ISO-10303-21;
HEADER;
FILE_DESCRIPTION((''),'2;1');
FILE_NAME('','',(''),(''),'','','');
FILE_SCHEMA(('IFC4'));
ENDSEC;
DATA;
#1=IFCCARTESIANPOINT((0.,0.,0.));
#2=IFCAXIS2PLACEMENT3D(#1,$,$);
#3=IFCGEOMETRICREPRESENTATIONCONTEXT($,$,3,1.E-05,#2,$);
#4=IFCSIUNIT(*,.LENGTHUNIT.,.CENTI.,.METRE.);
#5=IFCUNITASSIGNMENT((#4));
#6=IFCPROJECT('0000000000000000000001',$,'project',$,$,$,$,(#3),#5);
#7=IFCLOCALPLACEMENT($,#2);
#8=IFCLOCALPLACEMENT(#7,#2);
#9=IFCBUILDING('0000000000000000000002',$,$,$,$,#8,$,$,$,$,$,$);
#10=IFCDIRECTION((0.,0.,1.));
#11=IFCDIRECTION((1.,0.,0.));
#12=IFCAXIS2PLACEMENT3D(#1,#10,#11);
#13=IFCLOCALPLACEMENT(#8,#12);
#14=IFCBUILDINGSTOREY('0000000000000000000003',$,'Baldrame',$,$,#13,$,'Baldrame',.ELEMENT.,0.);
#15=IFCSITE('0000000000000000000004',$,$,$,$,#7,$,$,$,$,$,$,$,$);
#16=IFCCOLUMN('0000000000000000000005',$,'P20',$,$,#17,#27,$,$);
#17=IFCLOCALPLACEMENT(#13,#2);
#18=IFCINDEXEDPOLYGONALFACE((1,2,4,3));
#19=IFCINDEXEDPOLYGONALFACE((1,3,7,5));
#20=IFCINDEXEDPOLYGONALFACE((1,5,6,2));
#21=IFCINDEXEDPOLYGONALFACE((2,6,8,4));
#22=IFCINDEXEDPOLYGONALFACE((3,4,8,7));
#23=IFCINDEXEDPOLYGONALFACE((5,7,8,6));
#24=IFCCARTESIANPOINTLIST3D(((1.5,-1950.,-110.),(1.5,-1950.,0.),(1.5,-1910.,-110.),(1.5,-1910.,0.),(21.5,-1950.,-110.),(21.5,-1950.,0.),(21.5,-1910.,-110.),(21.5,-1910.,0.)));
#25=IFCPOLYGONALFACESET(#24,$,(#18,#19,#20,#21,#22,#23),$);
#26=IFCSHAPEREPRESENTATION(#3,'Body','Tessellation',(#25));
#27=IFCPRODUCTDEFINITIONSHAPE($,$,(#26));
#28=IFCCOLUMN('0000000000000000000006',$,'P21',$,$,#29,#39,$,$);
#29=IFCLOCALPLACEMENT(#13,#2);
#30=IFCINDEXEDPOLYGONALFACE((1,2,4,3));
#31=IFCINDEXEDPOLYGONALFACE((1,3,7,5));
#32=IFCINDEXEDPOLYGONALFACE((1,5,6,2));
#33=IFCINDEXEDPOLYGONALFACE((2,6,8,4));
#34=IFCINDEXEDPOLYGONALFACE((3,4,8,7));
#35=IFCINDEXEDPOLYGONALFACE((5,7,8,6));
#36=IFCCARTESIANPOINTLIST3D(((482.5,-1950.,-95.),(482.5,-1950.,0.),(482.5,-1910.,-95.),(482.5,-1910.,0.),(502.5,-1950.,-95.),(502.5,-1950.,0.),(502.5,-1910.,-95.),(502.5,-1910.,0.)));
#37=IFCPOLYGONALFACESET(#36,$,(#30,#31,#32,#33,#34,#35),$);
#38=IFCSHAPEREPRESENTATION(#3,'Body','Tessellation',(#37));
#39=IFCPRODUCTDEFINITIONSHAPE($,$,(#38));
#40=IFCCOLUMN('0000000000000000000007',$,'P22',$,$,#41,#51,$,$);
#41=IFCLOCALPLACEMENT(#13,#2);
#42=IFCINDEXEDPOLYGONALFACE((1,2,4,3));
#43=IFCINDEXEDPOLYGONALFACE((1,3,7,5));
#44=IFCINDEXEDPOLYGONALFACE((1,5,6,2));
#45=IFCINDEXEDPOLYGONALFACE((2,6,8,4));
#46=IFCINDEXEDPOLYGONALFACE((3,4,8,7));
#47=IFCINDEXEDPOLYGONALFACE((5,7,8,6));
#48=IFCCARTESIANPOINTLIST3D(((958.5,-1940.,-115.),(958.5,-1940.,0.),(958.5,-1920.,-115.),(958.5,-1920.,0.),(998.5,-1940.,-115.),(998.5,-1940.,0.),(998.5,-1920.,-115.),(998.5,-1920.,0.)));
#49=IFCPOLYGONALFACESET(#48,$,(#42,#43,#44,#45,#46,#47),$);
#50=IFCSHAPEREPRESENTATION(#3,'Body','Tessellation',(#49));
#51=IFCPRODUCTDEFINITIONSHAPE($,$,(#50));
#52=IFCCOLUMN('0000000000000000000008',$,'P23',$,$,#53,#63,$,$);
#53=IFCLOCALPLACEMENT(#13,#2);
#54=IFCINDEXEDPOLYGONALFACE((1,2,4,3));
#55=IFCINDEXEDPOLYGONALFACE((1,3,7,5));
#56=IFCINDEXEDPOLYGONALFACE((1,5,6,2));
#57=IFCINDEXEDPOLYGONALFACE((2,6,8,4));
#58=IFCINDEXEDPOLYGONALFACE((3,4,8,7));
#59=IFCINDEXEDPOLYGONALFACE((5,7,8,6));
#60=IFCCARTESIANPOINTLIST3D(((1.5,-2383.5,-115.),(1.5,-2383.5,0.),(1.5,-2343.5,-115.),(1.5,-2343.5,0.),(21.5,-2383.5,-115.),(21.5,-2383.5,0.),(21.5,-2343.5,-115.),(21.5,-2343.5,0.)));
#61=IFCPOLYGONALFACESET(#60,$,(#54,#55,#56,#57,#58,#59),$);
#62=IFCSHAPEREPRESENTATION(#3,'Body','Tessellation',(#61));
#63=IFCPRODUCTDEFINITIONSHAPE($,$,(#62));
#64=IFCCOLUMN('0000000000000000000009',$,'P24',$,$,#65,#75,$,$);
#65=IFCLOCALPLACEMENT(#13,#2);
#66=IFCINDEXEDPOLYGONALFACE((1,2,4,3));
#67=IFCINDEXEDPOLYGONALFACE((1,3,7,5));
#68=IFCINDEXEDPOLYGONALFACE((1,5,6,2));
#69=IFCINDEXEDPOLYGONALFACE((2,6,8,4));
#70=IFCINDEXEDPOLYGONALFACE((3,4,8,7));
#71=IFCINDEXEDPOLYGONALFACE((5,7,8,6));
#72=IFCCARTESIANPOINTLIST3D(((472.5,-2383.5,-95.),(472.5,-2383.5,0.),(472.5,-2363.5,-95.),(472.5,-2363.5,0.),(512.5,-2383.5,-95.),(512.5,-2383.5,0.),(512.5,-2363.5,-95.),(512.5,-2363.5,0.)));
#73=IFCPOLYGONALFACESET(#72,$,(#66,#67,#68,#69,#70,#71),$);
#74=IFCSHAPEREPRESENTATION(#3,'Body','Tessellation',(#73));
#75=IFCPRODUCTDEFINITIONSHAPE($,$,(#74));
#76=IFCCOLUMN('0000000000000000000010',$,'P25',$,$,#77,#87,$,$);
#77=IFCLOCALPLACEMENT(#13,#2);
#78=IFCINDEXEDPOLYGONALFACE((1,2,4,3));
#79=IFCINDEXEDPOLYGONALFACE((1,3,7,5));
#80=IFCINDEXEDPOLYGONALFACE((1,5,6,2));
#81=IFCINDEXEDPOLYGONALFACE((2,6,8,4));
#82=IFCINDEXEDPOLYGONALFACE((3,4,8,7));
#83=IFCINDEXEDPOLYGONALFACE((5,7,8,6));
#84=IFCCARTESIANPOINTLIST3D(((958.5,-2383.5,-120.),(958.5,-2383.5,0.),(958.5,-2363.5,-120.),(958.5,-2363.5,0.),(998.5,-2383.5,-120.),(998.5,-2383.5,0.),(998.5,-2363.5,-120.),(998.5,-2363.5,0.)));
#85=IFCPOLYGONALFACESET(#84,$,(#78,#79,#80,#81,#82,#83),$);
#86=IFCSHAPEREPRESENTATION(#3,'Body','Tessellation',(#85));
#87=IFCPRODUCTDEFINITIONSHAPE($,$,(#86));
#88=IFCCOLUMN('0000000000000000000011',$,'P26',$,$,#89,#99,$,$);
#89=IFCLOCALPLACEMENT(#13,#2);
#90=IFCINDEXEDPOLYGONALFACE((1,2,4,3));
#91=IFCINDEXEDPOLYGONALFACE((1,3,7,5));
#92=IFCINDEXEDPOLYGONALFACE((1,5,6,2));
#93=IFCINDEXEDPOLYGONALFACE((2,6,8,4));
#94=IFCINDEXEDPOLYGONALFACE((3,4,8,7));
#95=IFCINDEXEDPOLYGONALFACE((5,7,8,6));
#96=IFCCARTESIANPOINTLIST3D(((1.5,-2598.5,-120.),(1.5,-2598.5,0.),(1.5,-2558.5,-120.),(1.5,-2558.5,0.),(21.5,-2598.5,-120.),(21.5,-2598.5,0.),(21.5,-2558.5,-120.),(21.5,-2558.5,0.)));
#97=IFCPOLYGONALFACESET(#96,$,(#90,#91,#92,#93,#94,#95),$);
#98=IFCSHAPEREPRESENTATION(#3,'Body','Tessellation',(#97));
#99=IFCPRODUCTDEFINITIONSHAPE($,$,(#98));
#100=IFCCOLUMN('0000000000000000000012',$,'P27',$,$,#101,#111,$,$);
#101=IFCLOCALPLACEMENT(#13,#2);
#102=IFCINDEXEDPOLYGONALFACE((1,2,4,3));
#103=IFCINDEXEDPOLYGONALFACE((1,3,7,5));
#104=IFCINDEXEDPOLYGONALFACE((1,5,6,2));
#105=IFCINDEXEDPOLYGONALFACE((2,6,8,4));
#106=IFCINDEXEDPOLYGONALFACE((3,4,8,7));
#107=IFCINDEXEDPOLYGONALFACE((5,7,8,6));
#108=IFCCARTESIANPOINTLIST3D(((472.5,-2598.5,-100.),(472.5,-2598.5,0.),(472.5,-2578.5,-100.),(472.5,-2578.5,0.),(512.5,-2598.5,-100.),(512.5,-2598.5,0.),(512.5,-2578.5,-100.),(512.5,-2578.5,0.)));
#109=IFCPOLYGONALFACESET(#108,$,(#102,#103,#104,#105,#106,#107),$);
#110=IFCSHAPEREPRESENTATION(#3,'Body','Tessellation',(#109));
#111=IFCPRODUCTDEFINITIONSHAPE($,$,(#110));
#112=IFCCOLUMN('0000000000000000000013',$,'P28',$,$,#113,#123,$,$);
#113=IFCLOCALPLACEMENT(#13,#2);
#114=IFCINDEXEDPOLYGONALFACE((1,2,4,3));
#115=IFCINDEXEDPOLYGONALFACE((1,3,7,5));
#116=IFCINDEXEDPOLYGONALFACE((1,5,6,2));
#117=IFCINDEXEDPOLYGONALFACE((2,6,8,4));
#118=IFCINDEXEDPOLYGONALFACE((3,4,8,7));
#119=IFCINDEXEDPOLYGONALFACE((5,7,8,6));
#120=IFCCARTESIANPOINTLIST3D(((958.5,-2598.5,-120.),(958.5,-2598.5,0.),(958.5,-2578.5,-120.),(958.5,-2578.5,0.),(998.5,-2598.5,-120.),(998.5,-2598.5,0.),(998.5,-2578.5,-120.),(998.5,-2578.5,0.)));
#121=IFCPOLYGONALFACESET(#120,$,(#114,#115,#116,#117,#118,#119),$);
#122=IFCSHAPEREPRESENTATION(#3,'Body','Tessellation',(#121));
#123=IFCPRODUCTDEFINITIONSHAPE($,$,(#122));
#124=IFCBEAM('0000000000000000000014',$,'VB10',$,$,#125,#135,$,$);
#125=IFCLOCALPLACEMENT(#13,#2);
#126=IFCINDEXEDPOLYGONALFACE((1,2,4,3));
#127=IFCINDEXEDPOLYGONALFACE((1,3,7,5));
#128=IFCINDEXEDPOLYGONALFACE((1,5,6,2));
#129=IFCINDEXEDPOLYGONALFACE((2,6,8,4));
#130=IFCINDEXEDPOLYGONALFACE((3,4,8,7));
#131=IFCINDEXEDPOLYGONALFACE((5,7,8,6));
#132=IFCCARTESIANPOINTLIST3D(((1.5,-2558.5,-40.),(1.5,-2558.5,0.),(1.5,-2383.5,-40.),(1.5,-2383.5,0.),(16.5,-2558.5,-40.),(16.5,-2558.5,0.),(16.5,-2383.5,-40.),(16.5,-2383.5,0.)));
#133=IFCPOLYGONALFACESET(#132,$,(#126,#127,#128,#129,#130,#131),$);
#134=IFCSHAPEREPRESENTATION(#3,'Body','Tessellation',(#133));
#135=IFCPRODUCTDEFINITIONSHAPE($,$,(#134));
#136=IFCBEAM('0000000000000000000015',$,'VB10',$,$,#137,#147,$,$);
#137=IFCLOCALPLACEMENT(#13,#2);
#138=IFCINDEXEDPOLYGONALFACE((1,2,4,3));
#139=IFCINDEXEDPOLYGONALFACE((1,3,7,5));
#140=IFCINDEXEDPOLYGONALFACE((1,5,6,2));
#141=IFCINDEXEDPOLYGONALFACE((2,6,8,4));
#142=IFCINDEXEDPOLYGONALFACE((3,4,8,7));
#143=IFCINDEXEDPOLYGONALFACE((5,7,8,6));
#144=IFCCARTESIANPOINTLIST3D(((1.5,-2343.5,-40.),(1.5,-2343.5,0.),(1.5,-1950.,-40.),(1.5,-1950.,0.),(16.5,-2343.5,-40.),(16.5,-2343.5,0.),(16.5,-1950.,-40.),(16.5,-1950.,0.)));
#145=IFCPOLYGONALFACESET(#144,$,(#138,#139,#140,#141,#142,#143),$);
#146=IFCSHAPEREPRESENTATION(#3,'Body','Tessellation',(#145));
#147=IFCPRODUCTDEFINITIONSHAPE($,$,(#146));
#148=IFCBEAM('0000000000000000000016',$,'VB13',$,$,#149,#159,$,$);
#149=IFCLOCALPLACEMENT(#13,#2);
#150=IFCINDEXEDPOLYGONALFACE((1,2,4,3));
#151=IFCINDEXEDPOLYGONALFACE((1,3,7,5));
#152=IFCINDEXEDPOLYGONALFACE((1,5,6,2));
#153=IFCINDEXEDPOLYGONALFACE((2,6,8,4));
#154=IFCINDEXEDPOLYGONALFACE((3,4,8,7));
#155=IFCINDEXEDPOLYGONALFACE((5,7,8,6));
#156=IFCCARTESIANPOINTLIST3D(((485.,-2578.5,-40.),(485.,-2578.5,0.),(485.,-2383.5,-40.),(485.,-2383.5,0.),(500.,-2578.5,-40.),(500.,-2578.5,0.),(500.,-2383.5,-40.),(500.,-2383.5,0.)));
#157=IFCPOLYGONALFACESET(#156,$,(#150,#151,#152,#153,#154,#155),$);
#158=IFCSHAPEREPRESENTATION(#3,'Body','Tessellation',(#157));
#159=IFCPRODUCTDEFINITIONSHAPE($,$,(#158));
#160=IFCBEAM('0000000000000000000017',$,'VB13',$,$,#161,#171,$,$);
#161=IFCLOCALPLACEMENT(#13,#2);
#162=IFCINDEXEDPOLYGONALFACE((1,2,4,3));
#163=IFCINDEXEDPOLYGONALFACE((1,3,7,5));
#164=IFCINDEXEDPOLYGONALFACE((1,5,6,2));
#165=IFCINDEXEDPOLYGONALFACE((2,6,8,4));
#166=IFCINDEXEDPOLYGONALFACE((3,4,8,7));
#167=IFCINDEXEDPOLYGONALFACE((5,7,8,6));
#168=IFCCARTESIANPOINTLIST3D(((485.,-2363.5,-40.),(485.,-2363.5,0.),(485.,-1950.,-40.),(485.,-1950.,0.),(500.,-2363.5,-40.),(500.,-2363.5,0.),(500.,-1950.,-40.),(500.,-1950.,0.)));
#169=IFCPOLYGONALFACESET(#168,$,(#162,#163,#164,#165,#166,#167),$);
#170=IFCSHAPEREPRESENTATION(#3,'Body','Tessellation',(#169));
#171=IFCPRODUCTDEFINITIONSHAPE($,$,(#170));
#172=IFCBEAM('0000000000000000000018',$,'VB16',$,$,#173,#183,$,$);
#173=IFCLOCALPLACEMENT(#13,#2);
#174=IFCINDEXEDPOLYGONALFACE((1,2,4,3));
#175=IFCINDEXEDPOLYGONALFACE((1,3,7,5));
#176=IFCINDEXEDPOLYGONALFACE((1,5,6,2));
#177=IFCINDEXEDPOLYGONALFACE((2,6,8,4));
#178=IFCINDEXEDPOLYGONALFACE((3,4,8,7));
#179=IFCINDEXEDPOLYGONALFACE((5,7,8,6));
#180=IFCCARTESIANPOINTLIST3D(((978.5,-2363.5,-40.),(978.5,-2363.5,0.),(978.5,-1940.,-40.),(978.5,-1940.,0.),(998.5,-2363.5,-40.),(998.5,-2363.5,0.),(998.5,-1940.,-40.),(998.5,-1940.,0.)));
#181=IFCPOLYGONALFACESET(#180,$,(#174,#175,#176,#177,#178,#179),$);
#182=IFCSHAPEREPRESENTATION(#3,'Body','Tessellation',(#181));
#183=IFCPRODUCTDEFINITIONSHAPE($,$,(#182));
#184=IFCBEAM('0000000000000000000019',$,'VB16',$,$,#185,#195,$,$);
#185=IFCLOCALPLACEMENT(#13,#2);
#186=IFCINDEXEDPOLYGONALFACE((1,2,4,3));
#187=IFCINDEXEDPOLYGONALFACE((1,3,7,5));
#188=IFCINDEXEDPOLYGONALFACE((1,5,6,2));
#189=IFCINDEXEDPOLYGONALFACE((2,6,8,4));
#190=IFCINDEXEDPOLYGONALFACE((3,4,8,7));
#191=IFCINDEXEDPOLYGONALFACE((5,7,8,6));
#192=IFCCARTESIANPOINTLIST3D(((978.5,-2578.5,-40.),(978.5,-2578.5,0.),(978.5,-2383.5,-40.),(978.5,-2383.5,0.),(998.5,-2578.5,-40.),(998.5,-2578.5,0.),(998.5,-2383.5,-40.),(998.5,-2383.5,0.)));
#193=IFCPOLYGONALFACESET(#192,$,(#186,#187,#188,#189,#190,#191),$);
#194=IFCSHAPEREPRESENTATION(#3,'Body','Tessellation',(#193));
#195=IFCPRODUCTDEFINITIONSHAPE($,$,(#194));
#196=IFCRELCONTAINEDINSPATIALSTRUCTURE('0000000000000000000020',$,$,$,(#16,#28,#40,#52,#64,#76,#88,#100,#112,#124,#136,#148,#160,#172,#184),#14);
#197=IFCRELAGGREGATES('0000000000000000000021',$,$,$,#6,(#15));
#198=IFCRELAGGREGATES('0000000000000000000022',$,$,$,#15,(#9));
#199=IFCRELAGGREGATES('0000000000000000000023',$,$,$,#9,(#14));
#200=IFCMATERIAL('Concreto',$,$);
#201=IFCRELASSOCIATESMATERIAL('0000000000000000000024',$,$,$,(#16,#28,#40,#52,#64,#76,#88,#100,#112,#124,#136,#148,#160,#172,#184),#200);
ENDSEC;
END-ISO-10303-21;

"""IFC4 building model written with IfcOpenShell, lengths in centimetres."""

from ifc_helpers import new_model, si_unit, frame, origin, origin_with_axes, place, context, project, spatial, polyline, outline, extrude, material, element, save


model = new_model("IFC4")

# Units and contexts
context_of_model = context(None, 3, precision=1e-05, world=origin())
ifc_project = project(units=[si_unit("LENGTHUNIT", "METRE", prefix="CENTI")], contexts=[context_of_model])

# Site, building, storey
site_placement = place(None, origin())
site = spatial("IfcSite", under=ifc_project, at=site_placement)
building_placement = place(site_placement, origin())
building = spatial("IfcBuilding", under=site, at=building_placement)
storey_placement = place(building_placement, origin_with_axes())
storey = spatial("IfcBuildingStorey", under=building, at=storey_placement, Name="Baldrame", LongName="Baldrame", CompositionType="ELEMENT", Elevation=0.0)

# Columns
ifc_material = material(Name="Concreto")
column_1_placement = place(storey_placement, frame((11.5, -1930.0, 0.0), z_axis=(0.0, 0.0, 1.0), x_axis=(1.0, 0.0, 0.0)))
element("IfcColumn", 1, at=column_1_placement, inside=storey, material=ifc_material, Name="P20", context=context_of_model, shape_type="SolidModel", body=[
    extrude(outline(polyline([(-10.0, -20.0), (10.0, -20.0), (10.0, 20.0), (-10.0, 20.0), (-10.0, -20.0)])), frame((0.0, 0.0, -110.0), z_axis=(0.0, 0.0, 1.0), x_axis=(1.0, 0.0, 0.0)), (0.0, 0.0, 1.0), 110.0),
])
column_2_placement = place(storey_placement, frame((492.5, -1930.0, 0.0), z_axis=(0.0, 0.0, 1.0), x_axis=(1.0, 0.0, 0.0)))
element("IfcColumn", 2, at=column_2_placement, inside=storey, material=ifc_material, Name="P21", context=context_of_model, shape_type="SolidModel", body=[
    extrude(outline(polyline([(-10.0, -20.0), (10.0, -20.0), (10.0, 20.0), (-10.0, 20.0), (-10.0, -20.0)])), frame((0.0, 0.0, -95.0), z_axis=(0.0, 0.0, 1.0), x_axis=(1.0, 0.0, 0.0)), (0.0, 0.0, 1.0), 95.0),
])
column_3_placement = place(storey_placement, frame((978.5, -1930.0, 0.0), z_axis=(0.0, 0.0, 1.0), x_axis=(1.0, 0.0, 0.0)))
element("IfcColumn", 3, at=column_3_placement, inside=storey, material=ifc_material, Name="P22", context=context_of_model, shape_type="SolidModel", body=[
    extrude(outline(polyline([(-20.0, 10.0), (-20.0, -10.0), (20.0, -10.0), (20.0, 10.0), (-20.0, 10.0)])), frame((0.0, 0.0, -115.0), z_axis=(0.0, 0.0, 1.0), x_axis=(1.0, 0.0, 0.0)), (0.0, 0.0, 1.0), 115.0),
])
column_4_placement = place(storey_placement, frame((11.5, -2363.5, 0.0), z_axis=(0.0, 0.0, 1.0), x_axis=(1.0, 0.0, 0.0)))
element("IfcColumn", 4, at=column_4_placement, inside=storey, material=ifc_material, Name="P23", context=context_of_model, shape_type="SolidModel", body=[
    extrude(outline(polyline([(-10.0, -20.0), (10.0, -20.0), (10.0, 20.0), (-10.0, 20.0), (-10.0, -20.0)])), frame((0.0, 0.0, -115.0), z_axis=(0.0, 0.0, 1.0), x_axis=(1.0, 0.0, 0.0)), (0.0, 0.0, 1.0), 115.0),
])
column_5_placement = place(storey_placement, frame((492.5, -2373.5, 0.0), z_axis=(0.0, 0.0, 1.0), x_axis=(1.0, 0.0, 0.0)))
element("IfcColumn", 5, at=column_5_placement, inside=storey, material=ifc_material, Name="P24", context=context_of_model, shape_type="SolidModel", body=[
    extrude(outline(polyline([(-20.0, 10.0), (-20.0, -10.0), (20.0, -10.0), (20.0, 10.0), (-20.0, 10.0)])), frame((0.0, 0.0, -95.0), z_axis=(0.0, 0.0, 1.0), x_axis=(1.0, 0.0, 0.0)), (0.0, 0.0, 1.0), 95.0),
])
column_6_placement = place(storey_placement, frame((978.5, -2373.5, 0.0), z_axis=(0.0, 0.0, 1.0), x_axis=(1.0, 0.0, 0.0)))
element("IfcColumn", 6, at=column_6_placement, inside=storey, material=ifc_material, Name="P25", context=context_of_model, shape_type="SolidModel", body=[
    extrude(outline(polyline([(-20.0, 10.0), (-20.0, -10.0), (20.0, -10.0), (20.0, 10.0), (-20.0, 10.0)])), frame((0.0, 0.0, -120.0), z_axis=(0.0, 0.0, 1.0), x_axis=(1.0, 0.0, 0.0)), (0.0, 0.0, 1.0), 120.0),
])
column_7_placement = place(storey_placement, frame((11.5, -2578.5, 0.0), z_axis=(0.0, 0.0, 1.0), x_axis=(1.0, 0.0, 0.0)))
element("IfcColumn", 7, at=column_7_placement, inside=storey, material=ifc_material, Name="P26", context=context_of_model, shape_type="SolidModel", body=[
    extrude(outline(polyline([(-10.0, -20.0), (10.0, -20.0), (10.0, 20.0), (-10.0, 20.0), (-10.0, -20.0)])), frame((0.0, 0.0, -120.0), z_axis=(0.0, 0.0, 1.0), x_axis=(1.0, 0.0, 0.0)), (0.0, 0.0, 1.0), 120.0),
])
column_8_placement = place(storey_placement, frame((492.5, -2588.5, 0.0), z_axis=(0.0, 0.0, 1.0), x_axis=(1.0, 0.0, 0.0)))
element("IfcColumn", 8, at=column_8_placement, inside=storey, material=ifc_material, Name="P27", context=context_of_model, shape_type="SolidModel", body=[
    extrude(outline(polyline([(20.0, -10.0), (20.0, 10.0), (-20.0, 10.0), (-20.0, -10.0), (20.0, -10.0)])), frame((0.0, 0.0, -100.0), z_axis=(0.0, 0.0, 1.0), x_axis=(1.0, 0.0, 0.0)), (0.0, 0.0, 1.0), 100.0),
])
column_9_placement = place(storey_placement, frame((978.5, -2588.5, 0.0), z_axis=(0.0, 0.0, 1.0), x_axis=(1.0, 0.0, 0.0)))
element("IfcColumn", 9, at=column_9_placement, inside=storey, material=ifc_material, Name="P28", context=context_of_model, shape_type="SolidModel", body=[
    extrude(outline(polyline([(-20.0, 10.0), (-20.0, -10.0), (20.0, -10.0), (20.0, 10.0), (-20.0, 10.0)])), frame((0.0, 0.0, -120.0), z_axis=(0.0, 0.0, 1.0), x_axis=(1.0, 0.0, 0.0)), (0.0, 0.0, 1.0), 120.0),
])

# Beams
beam_1_placement = place(storey_placement, frame((9.0, -2471.0, 0.0), z_axis=(0.0, 0.0, 1.0), x_axis=(1.0, 0.0, 0.0)))
element("IfcBeam", 10, at=beam_1_placement, inside=storey, material=ifc_material, Name="VB10", context=context_of_model, shape_type="SolidModel", body=[
    extrude(outline(polyline([(-7.5, -20.0), (7.5, -20.0), (7.5, 20.0), (-7.5, 20.0), (-7.5, -20.0)])), frame((0.0, -87.5, -20.0), z_axis=(0.0, 1.0, 0.0), x_axis=(1.0, 0.0, 0.0)), (0.0, 0.0, 1.0), 175.0),
])
beam_2_placement = place(storey_placement, frame((9.0, -2146.75, 0.0), z_axis=(0.0, 0.0, 1.0), x_axis=(1.0, 0.0, 0.0)))
element("IfcBeam", 11, at=beam_2_placement, inside=storey, material=ifc_material, Name="VB10", context=context_of_model, shape_type="SolidModel", body=[
    extrude(outline(polyline([(-7.5, -20.0), (7.5, -20.0), (7.5, 20.0), (-7.5, 20.0), (-7.5, -20.0)])), frame((0.0, -196.75, -20.0), z_axis=(0.0, 1.0, 0.0), x_axis=(1.0, 0.0, 0.0)), (0.0, 0.0, 1.0), 393.5),
])
beam_3_placement = place(storey_placement, frame((492.5, -2481.0, 0.0), z_axis=(0.0, 0.0, 1.0), x_axis=(1.0, 0.0, 0.0)))
element("IfcBeam", 12, at=beam_3_placement, inside=storey, material=ifc_material, Name="VB13", context=context_of_model, shape_type="SolidModel", body=[
    extrude(outline(polyline([(-7.5, -20.0), (7.5, -20.0), (7.5, 20.0), (-7.5, 20.0), (-7.5, -20.0)])), frame((0.0, -97.5, -20.0), z_axis=(0.0, 1.0, 0.0), x_axis=(1.0, 0.0, 0.0)), (0.0, 0.0, 1.0), 195.0),
])
beam_4_placement = place(storey_placement, frame((492.5, -2156.75, 0.0), z_axis=(0.0, 0.0, 1.0), x_axis=(1.0, 0.0, 0.0)))
element("IfcBeam", 13, at=beam_4_placement, inside=storey, material=ifc_material, Name="VB13", context=context_of_model, shape_type="SolidModel", body=[
    extrude(outline(polyline([(-7.5, -20.0), (7.5, -20.0), (7.5, 20.0), (-7.5, 20.0), (-7.5, -20.0)])), frame((0.0, -206.75, -20.0), z_axis=(0.0, 1.0, 0.0), x_axis=(1.0, 0.0, 0.0)), (0.0, 0.0, 1.0), 413.5),
])
beam_5_placement = place(storey_placement, frame((988.5, -2151.75, 0.0), z_axis=(0.0, 0.0, 1.0), x_axis=(1.0, 0.0, 0.0)))
element("IfcBeam", 14, at=beam_5_placement, inside=storey, material=ifc_material, Name="VB16", context=context_of_model, shape_type="SolidModel", body=[
    extrude(outline(polyline([(-10.0, -20.0), (10.0, -20.0), (10.0, 20.0), (-10.0, 20.0), (-10.0, -20.0)])), frame((0.0, -211.75, -20.0), z_axis=(0.0, 1.0, 0.0), x_axis=(1.0, 0.0, 0.0)), (0.0, 0.0, 1.0), 423.5),
])
beam_6_placement = place(storey_placement, frame((988.5, -2481.0, 0.0), z_axis=(0.0, 0.0, 1.0), x_axis=(1.0, 0.0, 0.0)))
element("IfcBeam", 15, at=beam_6_placement, inside=storey, material=ifc_material, Name="VB16", context=context_of_model, shape_type="SolidModel", body=[
    extrude(outline(polyline([(-10.0, -20.0), (10.0, -20.0), (10.0, 20.0), (-10.0, 20.0), (-10.0, -20.0)])), frame((0.0, -97.5, -20.0), z_axis=(0.0, 1.0, 0.0), x_axis=(1.0, 0.0, 0.0)), (0.0, 0.0, 1.0), 195.0),
])

save(model, "model.ifc")
